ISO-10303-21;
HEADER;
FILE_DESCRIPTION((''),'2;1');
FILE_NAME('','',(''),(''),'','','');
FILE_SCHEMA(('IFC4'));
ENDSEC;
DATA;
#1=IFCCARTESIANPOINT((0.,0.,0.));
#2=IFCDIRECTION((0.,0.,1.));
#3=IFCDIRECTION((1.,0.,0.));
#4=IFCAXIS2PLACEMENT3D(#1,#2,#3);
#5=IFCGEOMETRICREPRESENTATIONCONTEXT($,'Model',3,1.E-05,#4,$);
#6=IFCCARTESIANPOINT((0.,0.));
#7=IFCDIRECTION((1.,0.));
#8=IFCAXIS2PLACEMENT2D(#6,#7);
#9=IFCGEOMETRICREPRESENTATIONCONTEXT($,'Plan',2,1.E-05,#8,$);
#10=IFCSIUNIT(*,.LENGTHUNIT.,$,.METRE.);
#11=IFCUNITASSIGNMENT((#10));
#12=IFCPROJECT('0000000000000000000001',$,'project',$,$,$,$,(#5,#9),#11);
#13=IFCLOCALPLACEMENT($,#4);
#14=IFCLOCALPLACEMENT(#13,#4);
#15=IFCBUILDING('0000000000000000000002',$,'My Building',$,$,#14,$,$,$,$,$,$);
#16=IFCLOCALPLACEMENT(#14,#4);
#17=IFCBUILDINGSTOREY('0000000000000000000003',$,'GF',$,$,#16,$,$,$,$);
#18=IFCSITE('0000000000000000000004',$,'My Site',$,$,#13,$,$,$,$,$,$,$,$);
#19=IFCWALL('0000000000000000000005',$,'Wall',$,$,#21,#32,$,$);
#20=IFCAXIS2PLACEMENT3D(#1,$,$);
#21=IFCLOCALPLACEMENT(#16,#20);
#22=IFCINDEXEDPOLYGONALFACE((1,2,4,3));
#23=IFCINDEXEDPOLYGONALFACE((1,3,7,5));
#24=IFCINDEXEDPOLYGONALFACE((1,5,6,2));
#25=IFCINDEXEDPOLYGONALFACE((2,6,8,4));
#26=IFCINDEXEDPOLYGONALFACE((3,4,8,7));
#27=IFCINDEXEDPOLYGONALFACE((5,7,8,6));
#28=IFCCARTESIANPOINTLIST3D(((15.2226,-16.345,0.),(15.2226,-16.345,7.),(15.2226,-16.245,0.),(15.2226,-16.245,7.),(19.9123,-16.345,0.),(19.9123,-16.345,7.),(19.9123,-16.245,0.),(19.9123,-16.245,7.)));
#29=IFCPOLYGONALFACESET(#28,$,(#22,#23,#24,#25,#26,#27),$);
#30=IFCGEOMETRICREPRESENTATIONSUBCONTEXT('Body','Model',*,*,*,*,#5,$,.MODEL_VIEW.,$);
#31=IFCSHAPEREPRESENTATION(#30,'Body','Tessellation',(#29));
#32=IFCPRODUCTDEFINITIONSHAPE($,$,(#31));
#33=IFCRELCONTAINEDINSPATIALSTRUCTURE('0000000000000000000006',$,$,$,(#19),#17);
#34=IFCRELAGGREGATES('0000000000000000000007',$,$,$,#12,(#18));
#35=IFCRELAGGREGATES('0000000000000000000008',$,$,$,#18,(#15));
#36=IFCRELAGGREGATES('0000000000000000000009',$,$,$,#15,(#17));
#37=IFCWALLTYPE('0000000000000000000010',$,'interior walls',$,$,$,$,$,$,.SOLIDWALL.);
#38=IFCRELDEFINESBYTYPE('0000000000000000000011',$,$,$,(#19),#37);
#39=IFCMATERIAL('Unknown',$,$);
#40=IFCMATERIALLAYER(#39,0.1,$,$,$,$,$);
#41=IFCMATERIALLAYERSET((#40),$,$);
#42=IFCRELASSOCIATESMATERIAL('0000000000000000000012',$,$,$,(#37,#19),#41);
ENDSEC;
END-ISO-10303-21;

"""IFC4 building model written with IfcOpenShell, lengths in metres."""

from ifc_helpers import new_model, si_unit, frame, origin_with_axes, origin_2d_with_axis, place, context, subcontext, project, spatial, line, indexed_curve, outline, extrude, material, layer, layer_set, layer_usage, type_object, element, save


model = new_model("IFC4")

# Units and contexts
model_context = context("Model", 3, precision=1e-05, world=origin_with_axes())
plan_context = context("Plan", 2, precision=1e-05, world=origin_2d_with_axis())
body_context_1 = subcontext(model_context, "Body", "Model", "MODEL_VIEW")
ifc_project = project(units=[si_unit("LENGTHUNIT", "METRE")], contexts=[model_context, plan_context])

# Site, building, storey
site_placement = place(None, origin_with_axes())
site = spatial("IfcSite", under=ifc_project, at=site_placement, Name="My Site")
building_placement = place(site_placement, origin_with_axes())
building = spatial("IfcBuilding", under=site, at=building_placement, Name="My Building")
storey_placement = place(building_placement, origin_with_axes())
storey = spatial("IfcBuildingStorey", under=building, at=storey_placement, Name="GF")

# Shared definitions
ifc_material = material(Name="Unknown")

# Shared definitions
ifc_layer_1 = layer(ifc_material, 0.1)
ifc_layer_set_1 = layer_set([ifc_layer_1])
wall_type = type_object("IfcWallType", Name="interior walls", PredefinedType="SOLIDWALL", material=ifc_layer_set_1)

# Wall
ifc_layer_usage_1 = layer_usage(ifc_layer_set_1, "AXIS2", "POSITIVE", 0.0)
wall_1_placement = place(storey_placement, frame((15.2226, -16.345, 0.0), z_axis=(0.0, 0.0, 1.0), x_axis=(1.0, 0.0, 0.0)))
element("IfcWall", 1, at=wall_1_placement, inside=storey, type_object=wall_type, material=ifc_layer_usage_1, Name="Wall", context=body_context_1, shape_type="SweptSolid", body=[
    extrude(outline(indexed_curve([(0.0, 0.0), (0.0, 0.1), (4.6897, 0.1), (4.6897, 0.0)], segments=[line(1, 2, 3, 4, 1)])), origin_with_axes(), (0.0, 0.0, 1.0), 7.0),
])

save(model, "model.ifc")
